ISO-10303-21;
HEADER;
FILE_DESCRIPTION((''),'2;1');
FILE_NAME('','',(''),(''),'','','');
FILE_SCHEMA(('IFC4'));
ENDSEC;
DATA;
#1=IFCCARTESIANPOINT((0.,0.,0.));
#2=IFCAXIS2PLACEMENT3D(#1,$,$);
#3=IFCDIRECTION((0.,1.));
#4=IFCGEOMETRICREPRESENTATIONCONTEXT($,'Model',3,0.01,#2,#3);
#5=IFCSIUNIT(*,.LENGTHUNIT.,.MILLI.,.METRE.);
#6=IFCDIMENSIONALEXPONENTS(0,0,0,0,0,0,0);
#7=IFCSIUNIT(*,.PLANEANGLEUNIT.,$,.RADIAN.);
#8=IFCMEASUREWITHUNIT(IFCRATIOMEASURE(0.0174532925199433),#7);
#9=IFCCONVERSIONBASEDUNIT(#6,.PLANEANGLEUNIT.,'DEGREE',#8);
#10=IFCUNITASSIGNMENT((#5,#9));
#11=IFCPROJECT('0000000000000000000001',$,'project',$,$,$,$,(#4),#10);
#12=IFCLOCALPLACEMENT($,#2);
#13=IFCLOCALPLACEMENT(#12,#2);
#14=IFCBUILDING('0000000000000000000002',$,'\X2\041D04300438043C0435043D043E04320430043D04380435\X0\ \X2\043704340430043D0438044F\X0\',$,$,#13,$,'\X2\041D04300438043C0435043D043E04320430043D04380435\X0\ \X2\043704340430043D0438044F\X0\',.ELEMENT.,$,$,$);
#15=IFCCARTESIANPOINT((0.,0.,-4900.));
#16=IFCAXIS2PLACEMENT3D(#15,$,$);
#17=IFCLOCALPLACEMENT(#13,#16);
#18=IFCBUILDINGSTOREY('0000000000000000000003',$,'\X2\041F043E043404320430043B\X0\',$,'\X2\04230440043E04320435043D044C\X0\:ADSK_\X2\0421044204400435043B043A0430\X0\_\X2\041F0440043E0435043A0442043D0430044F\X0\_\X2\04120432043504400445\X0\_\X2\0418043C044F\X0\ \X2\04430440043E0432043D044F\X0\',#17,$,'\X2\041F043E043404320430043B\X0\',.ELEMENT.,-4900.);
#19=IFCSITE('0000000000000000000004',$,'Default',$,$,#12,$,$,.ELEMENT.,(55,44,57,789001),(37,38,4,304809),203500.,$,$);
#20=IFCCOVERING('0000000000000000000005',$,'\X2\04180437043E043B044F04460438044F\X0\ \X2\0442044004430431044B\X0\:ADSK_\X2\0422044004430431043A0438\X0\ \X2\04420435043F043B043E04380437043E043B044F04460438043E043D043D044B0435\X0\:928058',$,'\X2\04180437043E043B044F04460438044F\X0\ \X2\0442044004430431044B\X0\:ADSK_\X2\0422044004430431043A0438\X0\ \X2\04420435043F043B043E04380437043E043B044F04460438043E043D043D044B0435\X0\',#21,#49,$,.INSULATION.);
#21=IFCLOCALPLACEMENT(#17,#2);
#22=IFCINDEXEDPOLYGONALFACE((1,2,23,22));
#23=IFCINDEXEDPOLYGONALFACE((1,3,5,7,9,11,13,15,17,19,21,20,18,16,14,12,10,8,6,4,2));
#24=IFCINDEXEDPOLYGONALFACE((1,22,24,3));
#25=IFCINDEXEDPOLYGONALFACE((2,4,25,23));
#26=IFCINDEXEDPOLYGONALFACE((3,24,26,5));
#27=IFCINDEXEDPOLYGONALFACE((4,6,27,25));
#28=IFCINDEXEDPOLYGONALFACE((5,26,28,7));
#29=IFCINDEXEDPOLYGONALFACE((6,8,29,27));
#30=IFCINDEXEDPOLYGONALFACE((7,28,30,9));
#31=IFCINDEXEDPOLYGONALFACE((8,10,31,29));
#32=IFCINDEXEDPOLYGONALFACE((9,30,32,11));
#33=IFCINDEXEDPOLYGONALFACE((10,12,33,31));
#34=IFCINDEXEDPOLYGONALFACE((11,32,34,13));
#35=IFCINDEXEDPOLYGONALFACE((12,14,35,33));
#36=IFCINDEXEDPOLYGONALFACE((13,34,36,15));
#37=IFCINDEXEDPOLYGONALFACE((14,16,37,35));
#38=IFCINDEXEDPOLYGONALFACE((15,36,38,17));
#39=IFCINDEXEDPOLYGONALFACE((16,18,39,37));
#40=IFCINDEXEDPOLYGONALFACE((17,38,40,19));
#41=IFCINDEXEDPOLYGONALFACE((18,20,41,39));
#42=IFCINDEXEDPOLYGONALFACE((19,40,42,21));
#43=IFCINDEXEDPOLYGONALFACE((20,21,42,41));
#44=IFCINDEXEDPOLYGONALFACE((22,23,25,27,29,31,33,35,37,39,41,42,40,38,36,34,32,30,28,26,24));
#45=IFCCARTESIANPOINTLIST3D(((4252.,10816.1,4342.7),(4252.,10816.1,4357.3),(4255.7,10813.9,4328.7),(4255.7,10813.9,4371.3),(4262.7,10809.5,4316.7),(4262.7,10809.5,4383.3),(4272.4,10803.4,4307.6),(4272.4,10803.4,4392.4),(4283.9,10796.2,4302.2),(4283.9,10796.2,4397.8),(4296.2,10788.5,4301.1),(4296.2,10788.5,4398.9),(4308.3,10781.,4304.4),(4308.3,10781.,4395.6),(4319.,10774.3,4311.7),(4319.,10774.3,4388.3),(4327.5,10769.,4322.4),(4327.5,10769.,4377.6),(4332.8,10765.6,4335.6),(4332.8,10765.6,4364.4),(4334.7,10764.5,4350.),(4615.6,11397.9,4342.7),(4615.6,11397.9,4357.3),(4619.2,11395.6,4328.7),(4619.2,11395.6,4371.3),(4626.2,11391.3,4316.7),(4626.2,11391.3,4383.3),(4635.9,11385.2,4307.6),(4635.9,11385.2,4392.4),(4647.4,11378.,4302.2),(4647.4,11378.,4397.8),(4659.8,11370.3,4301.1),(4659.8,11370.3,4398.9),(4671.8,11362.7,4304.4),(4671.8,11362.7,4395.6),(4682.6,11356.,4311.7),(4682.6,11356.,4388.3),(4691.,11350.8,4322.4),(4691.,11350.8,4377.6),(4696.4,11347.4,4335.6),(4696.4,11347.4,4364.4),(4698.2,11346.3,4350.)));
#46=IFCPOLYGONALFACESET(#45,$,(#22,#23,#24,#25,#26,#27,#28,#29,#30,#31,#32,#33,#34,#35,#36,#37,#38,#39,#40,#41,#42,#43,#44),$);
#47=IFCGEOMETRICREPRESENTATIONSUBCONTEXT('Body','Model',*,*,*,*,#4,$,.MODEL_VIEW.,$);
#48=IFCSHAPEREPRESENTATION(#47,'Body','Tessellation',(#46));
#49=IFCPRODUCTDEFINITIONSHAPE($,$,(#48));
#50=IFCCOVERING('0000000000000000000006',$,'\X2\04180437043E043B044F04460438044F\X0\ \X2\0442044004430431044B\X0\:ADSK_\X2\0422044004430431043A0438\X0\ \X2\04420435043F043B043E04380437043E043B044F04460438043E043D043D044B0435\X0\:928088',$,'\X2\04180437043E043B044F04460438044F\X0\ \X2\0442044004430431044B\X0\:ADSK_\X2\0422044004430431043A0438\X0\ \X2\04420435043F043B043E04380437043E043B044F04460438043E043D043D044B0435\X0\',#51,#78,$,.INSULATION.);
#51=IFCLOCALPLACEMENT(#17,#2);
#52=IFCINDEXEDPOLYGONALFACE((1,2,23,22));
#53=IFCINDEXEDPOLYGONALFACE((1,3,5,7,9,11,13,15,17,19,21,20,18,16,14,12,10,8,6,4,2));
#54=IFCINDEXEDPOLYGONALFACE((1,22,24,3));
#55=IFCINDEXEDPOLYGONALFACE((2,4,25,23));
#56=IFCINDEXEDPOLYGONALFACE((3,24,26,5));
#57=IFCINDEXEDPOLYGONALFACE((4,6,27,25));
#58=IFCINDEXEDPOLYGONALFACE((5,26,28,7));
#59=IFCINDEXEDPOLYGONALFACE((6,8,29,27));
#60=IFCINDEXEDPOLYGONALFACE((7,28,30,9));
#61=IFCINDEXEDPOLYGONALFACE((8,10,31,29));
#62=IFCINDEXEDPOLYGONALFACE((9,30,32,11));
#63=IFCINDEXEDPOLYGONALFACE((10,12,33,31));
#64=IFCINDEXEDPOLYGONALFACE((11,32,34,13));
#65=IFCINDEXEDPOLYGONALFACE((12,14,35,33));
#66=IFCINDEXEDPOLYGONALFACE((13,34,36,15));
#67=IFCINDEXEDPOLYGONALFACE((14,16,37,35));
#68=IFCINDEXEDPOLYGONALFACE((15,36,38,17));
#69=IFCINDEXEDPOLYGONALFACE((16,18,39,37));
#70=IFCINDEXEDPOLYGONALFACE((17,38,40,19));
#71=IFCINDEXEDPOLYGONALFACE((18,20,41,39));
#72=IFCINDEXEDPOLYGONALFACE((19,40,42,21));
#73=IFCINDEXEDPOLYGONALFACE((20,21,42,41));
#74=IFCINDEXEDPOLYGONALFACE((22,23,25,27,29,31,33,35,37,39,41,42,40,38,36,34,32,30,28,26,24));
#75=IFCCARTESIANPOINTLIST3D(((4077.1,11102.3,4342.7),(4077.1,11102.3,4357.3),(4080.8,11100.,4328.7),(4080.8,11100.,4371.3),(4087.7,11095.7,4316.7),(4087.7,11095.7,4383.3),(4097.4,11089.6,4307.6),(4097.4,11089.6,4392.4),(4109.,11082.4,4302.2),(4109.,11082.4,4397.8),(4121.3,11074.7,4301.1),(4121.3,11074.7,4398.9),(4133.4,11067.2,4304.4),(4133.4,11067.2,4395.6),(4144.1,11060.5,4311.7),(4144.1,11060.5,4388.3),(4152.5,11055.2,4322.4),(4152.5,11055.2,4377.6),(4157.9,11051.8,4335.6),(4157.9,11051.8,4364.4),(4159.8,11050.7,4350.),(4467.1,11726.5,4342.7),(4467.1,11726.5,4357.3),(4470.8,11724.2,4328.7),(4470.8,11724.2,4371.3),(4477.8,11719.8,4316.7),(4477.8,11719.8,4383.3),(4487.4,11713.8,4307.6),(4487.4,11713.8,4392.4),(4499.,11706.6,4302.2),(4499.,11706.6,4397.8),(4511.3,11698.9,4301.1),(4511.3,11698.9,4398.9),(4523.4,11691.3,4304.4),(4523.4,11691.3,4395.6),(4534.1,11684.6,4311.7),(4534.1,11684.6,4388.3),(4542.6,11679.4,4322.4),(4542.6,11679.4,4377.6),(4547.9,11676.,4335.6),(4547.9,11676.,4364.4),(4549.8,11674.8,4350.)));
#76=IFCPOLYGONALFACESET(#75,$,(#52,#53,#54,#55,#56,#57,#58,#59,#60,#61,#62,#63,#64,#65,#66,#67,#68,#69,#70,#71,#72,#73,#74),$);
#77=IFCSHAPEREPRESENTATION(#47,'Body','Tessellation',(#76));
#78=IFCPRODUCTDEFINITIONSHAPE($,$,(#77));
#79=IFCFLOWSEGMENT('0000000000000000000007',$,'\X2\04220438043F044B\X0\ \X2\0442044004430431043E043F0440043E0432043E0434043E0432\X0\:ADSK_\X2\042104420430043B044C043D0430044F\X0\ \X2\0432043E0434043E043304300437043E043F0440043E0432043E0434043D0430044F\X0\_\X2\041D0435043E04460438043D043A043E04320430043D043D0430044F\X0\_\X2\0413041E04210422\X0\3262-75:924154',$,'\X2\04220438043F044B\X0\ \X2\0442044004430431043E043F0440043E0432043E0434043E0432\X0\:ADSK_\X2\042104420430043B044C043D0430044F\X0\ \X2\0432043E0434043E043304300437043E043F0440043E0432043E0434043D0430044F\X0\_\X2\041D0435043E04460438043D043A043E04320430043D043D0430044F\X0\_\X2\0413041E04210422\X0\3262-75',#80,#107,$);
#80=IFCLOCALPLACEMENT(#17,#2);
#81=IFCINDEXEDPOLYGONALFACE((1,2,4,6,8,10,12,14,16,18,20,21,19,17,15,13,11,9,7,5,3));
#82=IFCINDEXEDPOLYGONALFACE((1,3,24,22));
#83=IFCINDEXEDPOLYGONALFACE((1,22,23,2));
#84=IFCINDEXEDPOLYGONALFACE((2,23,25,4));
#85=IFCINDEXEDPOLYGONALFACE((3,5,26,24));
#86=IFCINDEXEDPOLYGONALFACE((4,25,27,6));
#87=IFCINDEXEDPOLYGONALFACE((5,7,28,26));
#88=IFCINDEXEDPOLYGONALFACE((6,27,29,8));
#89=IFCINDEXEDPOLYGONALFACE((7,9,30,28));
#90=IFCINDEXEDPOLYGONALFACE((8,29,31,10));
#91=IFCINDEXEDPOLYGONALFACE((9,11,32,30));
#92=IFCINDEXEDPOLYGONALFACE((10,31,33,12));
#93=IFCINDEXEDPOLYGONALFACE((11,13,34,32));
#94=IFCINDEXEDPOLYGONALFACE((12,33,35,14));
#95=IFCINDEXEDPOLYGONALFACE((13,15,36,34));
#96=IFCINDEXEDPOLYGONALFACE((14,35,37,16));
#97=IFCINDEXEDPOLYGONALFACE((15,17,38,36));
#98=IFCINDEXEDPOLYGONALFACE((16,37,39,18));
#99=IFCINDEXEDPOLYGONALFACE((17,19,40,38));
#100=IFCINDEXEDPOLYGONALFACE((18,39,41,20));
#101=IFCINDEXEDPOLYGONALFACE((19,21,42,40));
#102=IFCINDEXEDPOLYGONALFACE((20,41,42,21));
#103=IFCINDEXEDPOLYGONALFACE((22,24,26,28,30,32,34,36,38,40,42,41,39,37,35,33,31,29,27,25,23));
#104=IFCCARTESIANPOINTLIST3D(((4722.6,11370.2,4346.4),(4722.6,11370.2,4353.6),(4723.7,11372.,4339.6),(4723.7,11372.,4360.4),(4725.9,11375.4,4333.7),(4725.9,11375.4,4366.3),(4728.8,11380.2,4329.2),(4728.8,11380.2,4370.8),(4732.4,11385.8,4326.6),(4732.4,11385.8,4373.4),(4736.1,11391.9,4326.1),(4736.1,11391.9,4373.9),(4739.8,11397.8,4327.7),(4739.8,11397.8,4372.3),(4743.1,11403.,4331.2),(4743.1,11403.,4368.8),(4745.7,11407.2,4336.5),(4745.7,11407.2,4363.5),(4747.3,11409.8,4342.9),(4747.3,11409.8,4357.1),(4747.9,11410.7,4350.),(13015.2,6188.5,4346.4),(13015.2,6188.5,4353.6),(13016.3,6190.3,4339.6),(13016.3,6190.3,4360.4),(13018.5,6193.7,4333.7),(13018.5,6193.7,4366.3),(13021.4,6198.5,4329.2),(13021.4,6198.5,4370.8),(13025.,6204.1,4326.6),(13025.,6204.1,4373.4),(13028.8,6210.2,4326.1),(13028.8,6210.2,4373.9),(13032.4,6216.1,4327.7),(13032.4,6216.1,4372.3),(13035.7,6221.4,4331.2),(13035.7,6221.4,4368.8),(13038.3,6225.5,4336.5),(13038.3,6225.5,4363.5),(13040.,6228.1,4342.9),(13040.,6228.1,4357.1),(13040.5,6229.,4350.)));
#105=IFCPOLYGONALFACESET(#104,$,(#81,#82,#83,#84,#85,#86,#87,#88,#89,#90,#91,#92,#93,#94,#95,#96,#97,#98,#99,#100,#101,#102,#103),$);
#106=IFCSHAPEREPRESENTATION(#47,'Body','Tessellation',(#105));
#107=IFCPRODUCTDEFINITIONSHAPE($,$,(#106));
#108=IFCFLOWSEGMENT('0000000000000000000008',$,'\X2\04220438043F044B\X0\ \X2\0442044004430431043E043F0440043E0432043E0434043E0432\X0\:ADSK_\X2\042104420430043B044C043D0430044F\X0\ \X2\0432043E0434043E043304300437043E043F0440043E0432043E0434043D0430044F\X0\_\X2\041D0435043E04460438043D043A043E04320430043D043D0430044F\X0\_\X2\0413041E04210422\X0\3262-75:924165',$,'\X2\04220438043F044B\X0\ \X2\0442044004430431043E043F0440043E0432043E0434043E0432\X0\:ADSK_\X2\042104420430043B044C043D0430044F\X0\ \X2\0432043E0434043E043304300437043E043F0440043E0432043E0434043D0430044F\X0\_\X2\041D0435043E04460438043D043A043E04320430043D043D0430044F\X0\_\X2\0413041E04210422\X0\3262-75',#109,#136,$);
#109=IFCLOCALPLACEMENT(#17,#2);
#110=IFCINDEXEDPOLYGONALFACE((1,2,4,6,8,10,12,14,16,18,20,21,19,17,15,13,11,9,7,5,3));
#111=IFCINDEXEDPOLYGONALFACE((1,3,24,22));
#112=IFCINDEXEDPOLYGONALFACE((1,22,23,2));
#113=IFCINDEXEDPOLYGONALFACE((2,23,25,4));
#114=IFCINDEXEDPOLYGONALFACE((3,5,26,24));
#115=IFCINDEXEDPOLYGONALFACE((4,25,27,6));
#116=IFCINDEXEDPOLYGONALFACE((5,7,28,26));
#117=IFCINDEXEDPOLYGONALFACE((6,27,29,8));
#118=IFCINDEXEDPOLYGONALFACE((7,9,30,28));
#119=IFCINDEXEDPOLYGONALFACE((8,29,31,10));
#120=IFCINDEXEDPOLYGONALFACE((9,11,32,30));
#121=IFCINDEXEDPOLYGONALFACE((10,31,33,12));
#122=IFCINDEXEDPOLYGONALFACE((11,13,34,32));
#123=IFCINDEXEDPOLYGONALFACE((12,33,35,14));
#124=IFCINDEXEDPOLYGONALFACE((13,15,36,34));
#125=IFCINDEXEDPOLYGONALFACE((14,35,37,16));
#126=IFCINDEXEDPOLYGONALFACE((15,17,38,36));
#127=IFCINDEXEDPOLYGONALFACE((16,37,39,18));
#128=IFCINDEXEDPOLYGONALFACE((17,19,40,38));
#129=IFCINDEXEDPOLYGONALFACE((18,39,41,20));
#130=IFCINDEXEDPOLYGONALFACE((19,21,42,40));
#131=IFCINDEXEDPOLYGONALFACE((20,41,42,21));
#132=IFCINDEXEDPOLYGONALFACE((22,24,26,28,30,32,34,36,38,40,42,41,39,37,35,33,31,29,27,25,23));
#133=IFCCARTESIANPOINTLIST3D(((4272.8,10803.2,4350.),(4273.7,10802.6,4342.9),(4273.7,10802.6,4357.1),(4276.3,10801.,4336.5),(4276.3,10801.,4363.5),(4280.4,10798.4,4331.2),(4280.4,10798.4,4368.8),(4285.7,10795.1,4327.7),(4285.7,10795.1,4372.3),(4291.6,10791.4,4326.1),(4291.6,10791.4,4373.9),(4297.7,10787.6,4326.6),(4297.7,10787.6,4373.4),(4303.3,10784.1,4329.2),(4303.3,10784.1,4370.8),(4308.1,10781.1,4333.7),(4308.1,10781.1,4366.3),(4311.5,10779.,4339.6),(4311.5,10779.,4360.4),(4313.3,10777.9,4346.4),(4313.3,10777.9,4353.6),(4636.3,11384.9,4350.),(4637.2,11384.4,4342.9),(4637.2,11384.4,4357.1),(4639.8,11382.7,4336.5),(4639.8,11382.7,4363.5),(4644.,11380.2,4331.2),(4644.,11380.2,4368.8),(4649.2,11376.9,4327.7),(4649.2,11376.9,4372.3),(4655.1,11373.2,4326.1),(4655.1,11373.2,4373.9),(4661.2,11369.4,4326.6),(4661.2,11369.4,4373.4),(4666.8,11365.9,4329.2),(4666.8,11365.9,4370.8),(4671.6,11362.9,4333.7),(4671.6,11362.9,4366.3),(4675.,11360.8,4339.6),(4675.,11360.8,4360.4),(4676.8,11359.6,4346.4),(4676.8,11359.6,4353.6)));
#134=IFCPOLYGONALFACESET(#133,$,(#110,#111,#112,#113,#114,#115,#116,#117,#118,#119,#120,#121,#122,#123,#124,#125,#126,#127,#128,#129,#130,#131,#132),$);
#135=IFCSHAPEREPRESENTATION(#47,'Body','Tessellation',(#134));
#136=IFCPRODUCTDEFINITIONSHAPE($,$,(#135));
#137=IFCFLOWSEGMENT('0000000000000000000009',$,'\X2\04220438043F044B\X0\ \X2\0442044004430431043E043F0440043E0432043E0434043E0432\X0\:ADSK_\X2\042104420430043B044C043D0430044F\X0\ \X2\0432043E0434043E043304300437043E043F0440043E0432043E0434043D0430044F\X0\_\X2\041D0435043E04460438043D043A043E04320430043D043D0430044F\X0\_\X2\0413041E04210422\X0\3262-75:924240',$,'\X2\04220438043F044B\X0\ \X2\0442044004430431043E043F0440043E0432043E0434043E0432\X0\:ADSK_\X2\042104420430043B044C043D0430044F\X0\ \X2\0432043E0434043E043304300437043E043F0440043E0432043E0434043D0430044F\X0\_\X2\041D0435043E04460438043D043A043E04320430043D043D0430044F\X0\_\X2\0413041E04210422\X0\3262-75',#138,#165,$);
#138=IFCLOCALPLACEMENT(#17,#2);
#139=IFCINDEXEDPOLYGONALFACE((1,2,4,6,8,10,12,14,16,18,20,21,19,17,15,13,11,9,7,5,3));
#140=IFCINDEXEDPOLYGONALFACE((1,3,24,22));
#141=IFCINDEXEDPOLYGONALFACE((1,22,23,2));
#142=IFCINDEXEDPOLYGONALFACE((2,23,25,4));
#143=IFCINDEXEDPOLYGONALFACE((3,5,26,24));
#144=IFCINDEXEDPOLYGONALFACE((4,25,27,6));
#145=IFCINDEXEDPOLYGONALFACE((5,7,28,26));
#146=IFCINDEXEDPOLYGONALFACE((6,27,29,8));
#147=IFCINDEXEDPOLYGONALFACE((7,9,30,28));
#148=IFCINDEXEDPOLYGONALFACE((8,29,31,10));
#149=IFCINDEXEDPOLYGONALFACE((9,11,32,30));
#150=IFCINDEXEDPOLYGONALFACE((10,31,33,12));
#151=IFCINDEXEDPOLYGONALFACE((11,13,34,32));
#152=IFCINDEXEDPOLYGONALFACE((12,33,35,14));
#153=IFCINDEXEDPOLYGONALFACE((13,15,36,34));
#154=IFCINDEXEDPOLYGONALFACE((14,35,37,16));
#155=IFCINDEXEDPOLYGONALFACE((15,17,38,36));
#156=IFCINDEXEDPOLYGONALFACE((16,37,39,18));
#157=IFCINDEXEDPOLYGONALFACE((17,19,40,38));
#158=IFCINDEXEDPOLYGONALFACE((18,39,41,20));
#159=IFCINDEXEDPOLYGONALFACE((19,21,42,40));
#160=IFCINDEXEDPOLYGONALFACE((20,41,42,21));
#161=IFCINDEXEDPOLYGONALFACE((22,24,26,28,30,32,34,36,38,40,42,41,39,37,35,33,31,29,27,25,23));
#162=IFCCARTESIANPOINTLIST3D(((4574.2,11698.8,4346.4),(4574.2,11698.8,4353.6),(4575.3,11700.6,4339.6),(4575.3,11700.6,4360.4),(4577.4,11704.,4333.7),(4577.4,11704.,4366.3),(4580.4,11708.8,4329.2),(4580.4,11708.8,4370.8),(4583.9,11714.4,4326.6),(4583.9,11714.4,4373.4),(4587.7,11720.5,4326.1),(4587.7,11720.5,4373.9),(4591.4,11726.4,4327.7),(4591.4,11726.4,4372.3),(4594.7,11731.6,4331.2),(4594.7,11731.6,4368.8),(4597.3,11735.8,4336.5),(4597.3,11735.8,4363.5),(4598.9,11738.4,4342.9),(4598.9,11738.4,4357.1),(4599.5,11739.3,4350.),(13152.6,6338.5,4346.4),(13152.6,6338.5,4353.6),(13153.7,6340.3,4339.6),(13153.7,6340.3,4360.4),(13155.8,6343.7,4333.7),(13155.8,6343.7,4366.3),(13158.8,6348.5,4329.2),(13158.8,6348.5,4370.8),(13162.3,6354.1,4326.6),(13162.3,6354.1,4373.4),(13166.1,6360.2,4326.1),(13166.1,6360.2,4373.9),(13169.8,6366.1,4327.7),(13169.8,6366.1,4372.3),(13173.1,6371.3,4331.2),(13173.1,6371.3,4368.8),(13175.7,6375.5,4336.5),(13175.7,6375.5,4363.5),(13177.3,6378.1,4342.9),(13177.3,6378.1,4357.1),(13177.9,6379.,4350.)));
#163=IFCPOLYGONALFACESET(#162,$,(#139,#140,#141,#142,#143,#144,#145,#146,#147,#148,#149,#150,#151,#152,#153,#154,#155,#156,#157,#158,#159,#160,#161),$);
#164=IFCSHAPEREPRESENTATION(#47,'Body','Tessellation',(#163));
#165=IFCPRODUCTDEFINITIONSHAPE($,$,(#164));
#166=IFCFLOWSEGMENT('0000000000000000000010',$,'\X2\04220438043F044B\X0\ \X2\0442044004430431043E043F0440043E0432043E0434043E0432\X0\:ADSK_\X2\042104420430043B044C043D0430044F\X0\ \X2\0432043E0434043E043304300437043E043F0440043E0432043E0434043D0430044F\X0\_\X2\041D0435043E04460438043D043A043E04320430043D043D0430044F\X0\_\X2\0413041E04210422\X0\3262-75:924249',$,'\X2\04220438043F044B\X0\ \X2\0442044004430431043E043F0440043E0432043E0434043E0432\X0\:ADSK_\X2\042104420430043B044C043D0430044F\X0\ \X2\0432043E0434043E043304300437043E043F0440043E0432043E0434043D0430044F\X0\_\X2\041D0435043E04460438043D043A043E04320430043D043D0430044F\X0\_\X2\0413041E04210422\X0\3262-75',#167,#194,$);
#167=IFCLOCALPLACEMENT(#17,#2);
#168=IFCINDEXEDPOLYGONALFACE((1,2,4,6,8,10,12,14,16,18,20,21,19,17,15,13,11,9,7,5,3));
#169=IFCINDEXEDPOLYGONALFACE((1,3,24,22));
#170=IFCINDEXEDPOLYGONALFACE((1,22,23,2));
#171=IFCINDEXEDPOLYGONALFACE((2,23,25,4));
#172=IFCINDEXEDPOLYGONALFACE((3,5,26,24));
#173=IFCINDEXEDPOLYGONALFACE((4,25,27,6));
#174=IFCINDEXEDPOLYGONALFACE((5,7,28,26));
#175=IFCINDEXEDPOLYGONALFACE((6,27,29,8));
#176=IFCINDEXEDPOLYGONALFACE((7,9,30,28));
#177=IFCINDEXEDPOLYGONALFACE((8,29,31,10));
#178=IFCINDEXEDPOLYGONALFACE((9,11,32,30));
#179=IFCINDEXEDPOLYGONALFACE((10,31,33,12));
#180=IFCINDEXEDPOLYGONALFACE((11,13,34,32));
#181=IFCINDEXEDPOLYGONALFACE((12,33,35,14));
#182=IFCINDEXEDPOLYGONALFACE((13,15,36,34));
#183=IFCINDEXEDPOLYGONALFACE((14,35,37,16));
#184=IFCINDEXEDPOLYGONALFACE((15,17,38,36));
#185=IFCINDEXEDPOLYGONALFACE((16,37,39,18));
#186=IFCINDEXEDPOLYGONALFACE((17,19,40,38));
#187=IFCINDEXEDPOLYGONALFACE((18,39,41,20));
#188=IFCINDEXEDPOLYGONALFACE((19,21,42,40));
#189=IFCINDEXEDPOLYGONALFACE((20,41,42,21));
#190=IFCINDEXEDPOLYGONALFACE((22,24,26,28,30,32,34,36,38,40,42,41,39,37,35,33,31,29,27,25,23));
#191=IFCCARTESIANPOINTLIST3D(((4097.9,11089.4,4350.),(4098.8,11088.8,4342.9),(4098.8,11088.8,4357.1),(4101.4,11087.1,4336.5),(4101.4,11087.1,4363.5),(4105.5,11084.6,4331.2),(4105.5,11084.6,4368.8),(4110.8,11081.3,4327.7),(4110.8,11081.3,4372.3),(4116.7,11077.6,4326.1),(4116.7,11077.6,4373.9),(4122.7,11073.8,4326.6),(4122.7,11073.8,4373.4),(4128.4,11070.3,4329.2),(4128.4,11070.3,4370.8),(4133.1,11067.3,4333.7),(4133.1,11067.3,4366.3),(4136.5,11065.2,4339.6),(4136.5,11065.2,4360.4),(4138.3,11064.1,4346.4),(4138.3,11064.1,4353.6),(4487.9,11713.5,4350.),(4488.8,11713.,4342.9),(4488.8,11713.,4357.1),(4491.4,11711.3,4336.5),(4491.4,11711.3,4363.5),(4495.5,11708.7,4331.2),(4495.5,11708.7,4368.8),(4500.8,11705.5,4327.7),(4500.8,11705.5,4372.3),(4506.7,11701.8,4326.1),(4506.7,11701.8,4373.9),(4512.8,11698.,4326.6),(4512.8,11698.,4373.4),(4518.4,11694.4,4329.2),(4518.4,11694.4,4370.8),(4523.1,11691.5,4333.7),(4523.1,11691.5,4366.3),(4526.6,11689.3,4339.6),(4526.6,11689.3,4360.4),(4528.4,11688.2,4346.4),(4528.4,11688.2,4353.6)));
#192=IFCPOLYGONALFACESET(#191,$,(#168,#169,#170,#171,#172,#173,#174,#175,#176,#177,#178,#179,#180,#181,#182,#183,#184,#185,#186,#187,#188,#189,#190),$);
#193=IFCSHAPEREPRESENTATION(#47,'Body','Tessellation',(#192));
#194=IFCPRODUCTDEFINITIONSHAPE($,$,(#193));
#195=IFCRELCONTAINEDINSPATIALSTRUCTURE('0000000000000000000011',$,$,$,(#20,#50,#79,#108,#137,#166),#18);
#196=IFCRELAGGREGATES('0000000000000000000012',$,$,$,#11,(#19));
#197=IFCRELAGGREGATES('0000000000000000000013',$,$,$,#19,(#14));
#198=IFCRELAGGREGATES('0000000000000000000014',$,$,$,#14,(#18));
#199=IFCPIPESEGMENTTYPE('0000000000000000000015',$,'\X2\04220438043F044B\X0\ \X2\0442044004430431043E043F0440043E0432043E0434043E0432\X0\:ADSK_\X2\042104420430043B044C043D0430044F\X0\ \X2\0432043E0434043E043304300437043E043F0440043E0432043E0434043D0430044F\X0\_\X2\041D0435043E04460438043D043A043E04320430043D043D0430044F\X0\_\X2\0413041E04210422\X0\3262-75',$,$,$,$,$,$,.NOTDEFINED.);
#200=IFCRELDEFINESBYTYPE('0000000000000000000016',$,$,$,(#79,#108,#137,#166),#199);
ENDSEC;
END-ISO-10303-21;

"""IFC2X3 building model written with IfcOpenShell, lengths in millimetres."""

from ifc_helpers import new_model, entity, si_unit, converted_unit, direction, frame, origin, origin_2d_with_axis, place, context, subcontext, project, spatial, circle, extrude, type_object, element, save


model = new_model("IFC2X3")

# Units and contexts
model_context = context("Model", 3, precision=0.01, world=origin(), true_north=direction((0.0, 1.0)))
body_context = subcontext(model_context, "Body", "Model", "MODEL_VIEW")
ifc_project = project(units=[si_unit("LENGTHUNIT", "METRE", prefix="MILLI"), converted_unit("PLANEANGLEUNIT", "DEGREE", entity("IfcRatioMeasure", 0.0174532925199433), si_unit("PLANEANGLEUNIT", "RADIAN"), dimensions=[0, 0, 0, 0, 0, 0, 0])], contexts=[model_context])

# Site, building, storey
site_placement = place(None, origin())
site = spatial("IfcSite", under=ifc_project, at=site_placement, Name="Default", CompositionType="ELEMENT", RefLatitude=(55, 44, 57, 789001), RefLongitude=(37, 38, 4, 304809), RefElevation=203500.0)
building_placement = place(site_placement, origin())
building = spatial("IfcBuilding", under=site, at=building_placement, Name="Наименование здания", LongName="Наименование здания", CompositionType="ELEMENT")
storey_placement = place(building_placement, frame((0.0, 0.0, -4900.0)))
storey = spatial("IfcBuildingStorey", under=building, at=storey_placement, Name="Подвал", ObjectType="Уровень:ADSK_Стрелка_Проектная_Вверх_Имя уровня", LongName="Подвал", CompositionType="ELEMENT", Elevation=-4900.0)

# Coverings
covering_1_placement = place(storey_placement, frame((4250.0, 10762.9, 4299.4)))
element("IfcCovering", 1, at=covering_1_placement, inside=storey, Name="Изоляция трубы:ADSK_Трубки теплоизоляционные:928058", ObjectType="Изоляция трубы:ADSK_Трубки теплоизоляционные", PredefinedType="INSULATION", context=body_context, shape_type="SweptSolid", body=[
    extrude(circle(Radius=49.0, at=origin_2d_with_axis()), frame((43.1, 27.6, 50.6), z_axis=(0.529912, 0.848053, 0.0), x_axis=(0.848053, -0.529912, 0.0)), (0.0, 0.0, 1.0), 686.0),
])
covering_2_placement = place(storey_placement, frame((4075.1, 11049.1, 4299.4)))
element("IfcCovering", 2, at=covering_2_placement, inside=storey, Name="Изоляция трубы:ADSK_Трубки теплоизоляционные:928088", ObjectType="Изоляция трубы:ADSK_Трубки теплоизоляционные", PredefinedType="INSULATION", context=body_context, shape_type="SweptSolid", body=[
    extrude(circle(Radius=49.0, at=origin_2d_with_axis()), frame((43.1, 27.6, 50.6), z_axis=(0.529912, 0.848053, 0.0), x_axis=(0.848053, -0.529912, 0.0)), (0.0, 0.0, 1.0), 736.0),
])

# Flow segments
pipe_segment_type = type_object("IfcPipeSegmentType", Name="Типы трубопроводов:ADSK_Стальная водогазопроводная_Неоцинкованная_ГОСТ3262-75", PredefinedType="NOTDEFINED")
flow_segment_1_placement = place(storey_placement, frame((4720.9, 6186.7, 4324.4)))
element("IfcFlowSegment", 3, at=flow_segment_1_placement, inside=storey, type_object=pipe_segment_type, Name="Типы трубопроводов:ADSK_Стальная водогазопроводная_Неоцинкованная_ГОСТ3262-75:924154", ObjectType="Типы трубопроводов:ADSK_Стальная водогазопроводная_Неоцинкованная_ГОСТ3262-75", context=body_context, shape_type="SweptSolid", body=[
    extrude(circle(Radius=24.0, at=origin_2d_with_axis()), frame((8306.9, 21.9, 25.6), z_axis=(-0.848053, 0.529912, 0.0), x_axis=(0.529912, 0.848053, 0.0)), (0.0, 0.0, 1.0), 9778.4),
])
flow_segment_2_placement = place(storey_placement, frame((4271.2, 10776.1, 4324.4)))
element("IfcFlowSegment", 4, at=flow_segment_2_placement, inside=storey, type_object=pipe_segment_type, Name="Типы трубопроводов:ADSK_Стальная водогазопроводная_Неоцинкованная_ГОСТ3262-75:924165", ObjectType="Типы трубопроводов:ADSK_Стальная водогазопроводная_Неоцинкованная_ГОСТ3262-75", context=body_context, shape_type="SweptSolid", body=[
    extrude(circle(Radius=24.0, at=origin_2d_with_axis()), frame((21.9, 14.3, 25.6), z_axis=(0.529912, 0.848053, 0.0), x_axis=(-0.848053, 0.529912, 0.0)), (0.0, 0.0, 1.0), 686.0),
])
flow_segment_3_placement = place(storey_placement, frame((4572.4, 6336.7, 4324.4)))
element("IfcFlowSegment", 5, at=flow_segment_3_placement, inside=storey, type_object=pipe_segment_type, Name="Типы трубопроводов:ADSK_Стальная водогазопроводная_Неоцинкованная_ГОСТ3262-75:924240", ObjectType="Типы трубопроводов:ADSK_Стальная водогазопроводная_Неоцинкованная_ГОСТ3262-75", context=body_context, shape_type="SweptSolid", body=[
    extrude(circle(Radius=24.0, at=origin_2d_with_axis()), frame((14.3, 5382.2, 25.6), z_axis=(0.848053, -0.529912, 0.0), x_axis=(0.529912, 0.848053, 0.0)), (0.0, 0.0, 1.0), 10115.4),
])
flow_segment_4_placement = place(storey_placement, frame((4096.3, 11062.3, 4324.4)))
element("IfcFlowSegment", 6, at=flow_segment_4_placement, inside=storey, type_object=pipe_segment_type, Name="Типы трубопроводов:ADSK_Стальная водогазопроводная_Неоцинкованная_ГОСТ3262-75:924249", ObjectType="Типы трубопроводов:ADSK_Стальная водогазопроводная_Неоцинкованная_ГОСТ3262-75", context=body_context, shape_type="SweptSolid", body=[
    extrude(circle(Radius=24.0, at=origin_2d_with_axis()), frame((21.9, 14.3, 25.6), z_axis=(0.529912, 0.848053, 0.0), x_axis=(-0.848053, 0.529912, 0.0)), (0.0, 0.0, 1.0), 736.0),
])

save(model, "model.ifc")
